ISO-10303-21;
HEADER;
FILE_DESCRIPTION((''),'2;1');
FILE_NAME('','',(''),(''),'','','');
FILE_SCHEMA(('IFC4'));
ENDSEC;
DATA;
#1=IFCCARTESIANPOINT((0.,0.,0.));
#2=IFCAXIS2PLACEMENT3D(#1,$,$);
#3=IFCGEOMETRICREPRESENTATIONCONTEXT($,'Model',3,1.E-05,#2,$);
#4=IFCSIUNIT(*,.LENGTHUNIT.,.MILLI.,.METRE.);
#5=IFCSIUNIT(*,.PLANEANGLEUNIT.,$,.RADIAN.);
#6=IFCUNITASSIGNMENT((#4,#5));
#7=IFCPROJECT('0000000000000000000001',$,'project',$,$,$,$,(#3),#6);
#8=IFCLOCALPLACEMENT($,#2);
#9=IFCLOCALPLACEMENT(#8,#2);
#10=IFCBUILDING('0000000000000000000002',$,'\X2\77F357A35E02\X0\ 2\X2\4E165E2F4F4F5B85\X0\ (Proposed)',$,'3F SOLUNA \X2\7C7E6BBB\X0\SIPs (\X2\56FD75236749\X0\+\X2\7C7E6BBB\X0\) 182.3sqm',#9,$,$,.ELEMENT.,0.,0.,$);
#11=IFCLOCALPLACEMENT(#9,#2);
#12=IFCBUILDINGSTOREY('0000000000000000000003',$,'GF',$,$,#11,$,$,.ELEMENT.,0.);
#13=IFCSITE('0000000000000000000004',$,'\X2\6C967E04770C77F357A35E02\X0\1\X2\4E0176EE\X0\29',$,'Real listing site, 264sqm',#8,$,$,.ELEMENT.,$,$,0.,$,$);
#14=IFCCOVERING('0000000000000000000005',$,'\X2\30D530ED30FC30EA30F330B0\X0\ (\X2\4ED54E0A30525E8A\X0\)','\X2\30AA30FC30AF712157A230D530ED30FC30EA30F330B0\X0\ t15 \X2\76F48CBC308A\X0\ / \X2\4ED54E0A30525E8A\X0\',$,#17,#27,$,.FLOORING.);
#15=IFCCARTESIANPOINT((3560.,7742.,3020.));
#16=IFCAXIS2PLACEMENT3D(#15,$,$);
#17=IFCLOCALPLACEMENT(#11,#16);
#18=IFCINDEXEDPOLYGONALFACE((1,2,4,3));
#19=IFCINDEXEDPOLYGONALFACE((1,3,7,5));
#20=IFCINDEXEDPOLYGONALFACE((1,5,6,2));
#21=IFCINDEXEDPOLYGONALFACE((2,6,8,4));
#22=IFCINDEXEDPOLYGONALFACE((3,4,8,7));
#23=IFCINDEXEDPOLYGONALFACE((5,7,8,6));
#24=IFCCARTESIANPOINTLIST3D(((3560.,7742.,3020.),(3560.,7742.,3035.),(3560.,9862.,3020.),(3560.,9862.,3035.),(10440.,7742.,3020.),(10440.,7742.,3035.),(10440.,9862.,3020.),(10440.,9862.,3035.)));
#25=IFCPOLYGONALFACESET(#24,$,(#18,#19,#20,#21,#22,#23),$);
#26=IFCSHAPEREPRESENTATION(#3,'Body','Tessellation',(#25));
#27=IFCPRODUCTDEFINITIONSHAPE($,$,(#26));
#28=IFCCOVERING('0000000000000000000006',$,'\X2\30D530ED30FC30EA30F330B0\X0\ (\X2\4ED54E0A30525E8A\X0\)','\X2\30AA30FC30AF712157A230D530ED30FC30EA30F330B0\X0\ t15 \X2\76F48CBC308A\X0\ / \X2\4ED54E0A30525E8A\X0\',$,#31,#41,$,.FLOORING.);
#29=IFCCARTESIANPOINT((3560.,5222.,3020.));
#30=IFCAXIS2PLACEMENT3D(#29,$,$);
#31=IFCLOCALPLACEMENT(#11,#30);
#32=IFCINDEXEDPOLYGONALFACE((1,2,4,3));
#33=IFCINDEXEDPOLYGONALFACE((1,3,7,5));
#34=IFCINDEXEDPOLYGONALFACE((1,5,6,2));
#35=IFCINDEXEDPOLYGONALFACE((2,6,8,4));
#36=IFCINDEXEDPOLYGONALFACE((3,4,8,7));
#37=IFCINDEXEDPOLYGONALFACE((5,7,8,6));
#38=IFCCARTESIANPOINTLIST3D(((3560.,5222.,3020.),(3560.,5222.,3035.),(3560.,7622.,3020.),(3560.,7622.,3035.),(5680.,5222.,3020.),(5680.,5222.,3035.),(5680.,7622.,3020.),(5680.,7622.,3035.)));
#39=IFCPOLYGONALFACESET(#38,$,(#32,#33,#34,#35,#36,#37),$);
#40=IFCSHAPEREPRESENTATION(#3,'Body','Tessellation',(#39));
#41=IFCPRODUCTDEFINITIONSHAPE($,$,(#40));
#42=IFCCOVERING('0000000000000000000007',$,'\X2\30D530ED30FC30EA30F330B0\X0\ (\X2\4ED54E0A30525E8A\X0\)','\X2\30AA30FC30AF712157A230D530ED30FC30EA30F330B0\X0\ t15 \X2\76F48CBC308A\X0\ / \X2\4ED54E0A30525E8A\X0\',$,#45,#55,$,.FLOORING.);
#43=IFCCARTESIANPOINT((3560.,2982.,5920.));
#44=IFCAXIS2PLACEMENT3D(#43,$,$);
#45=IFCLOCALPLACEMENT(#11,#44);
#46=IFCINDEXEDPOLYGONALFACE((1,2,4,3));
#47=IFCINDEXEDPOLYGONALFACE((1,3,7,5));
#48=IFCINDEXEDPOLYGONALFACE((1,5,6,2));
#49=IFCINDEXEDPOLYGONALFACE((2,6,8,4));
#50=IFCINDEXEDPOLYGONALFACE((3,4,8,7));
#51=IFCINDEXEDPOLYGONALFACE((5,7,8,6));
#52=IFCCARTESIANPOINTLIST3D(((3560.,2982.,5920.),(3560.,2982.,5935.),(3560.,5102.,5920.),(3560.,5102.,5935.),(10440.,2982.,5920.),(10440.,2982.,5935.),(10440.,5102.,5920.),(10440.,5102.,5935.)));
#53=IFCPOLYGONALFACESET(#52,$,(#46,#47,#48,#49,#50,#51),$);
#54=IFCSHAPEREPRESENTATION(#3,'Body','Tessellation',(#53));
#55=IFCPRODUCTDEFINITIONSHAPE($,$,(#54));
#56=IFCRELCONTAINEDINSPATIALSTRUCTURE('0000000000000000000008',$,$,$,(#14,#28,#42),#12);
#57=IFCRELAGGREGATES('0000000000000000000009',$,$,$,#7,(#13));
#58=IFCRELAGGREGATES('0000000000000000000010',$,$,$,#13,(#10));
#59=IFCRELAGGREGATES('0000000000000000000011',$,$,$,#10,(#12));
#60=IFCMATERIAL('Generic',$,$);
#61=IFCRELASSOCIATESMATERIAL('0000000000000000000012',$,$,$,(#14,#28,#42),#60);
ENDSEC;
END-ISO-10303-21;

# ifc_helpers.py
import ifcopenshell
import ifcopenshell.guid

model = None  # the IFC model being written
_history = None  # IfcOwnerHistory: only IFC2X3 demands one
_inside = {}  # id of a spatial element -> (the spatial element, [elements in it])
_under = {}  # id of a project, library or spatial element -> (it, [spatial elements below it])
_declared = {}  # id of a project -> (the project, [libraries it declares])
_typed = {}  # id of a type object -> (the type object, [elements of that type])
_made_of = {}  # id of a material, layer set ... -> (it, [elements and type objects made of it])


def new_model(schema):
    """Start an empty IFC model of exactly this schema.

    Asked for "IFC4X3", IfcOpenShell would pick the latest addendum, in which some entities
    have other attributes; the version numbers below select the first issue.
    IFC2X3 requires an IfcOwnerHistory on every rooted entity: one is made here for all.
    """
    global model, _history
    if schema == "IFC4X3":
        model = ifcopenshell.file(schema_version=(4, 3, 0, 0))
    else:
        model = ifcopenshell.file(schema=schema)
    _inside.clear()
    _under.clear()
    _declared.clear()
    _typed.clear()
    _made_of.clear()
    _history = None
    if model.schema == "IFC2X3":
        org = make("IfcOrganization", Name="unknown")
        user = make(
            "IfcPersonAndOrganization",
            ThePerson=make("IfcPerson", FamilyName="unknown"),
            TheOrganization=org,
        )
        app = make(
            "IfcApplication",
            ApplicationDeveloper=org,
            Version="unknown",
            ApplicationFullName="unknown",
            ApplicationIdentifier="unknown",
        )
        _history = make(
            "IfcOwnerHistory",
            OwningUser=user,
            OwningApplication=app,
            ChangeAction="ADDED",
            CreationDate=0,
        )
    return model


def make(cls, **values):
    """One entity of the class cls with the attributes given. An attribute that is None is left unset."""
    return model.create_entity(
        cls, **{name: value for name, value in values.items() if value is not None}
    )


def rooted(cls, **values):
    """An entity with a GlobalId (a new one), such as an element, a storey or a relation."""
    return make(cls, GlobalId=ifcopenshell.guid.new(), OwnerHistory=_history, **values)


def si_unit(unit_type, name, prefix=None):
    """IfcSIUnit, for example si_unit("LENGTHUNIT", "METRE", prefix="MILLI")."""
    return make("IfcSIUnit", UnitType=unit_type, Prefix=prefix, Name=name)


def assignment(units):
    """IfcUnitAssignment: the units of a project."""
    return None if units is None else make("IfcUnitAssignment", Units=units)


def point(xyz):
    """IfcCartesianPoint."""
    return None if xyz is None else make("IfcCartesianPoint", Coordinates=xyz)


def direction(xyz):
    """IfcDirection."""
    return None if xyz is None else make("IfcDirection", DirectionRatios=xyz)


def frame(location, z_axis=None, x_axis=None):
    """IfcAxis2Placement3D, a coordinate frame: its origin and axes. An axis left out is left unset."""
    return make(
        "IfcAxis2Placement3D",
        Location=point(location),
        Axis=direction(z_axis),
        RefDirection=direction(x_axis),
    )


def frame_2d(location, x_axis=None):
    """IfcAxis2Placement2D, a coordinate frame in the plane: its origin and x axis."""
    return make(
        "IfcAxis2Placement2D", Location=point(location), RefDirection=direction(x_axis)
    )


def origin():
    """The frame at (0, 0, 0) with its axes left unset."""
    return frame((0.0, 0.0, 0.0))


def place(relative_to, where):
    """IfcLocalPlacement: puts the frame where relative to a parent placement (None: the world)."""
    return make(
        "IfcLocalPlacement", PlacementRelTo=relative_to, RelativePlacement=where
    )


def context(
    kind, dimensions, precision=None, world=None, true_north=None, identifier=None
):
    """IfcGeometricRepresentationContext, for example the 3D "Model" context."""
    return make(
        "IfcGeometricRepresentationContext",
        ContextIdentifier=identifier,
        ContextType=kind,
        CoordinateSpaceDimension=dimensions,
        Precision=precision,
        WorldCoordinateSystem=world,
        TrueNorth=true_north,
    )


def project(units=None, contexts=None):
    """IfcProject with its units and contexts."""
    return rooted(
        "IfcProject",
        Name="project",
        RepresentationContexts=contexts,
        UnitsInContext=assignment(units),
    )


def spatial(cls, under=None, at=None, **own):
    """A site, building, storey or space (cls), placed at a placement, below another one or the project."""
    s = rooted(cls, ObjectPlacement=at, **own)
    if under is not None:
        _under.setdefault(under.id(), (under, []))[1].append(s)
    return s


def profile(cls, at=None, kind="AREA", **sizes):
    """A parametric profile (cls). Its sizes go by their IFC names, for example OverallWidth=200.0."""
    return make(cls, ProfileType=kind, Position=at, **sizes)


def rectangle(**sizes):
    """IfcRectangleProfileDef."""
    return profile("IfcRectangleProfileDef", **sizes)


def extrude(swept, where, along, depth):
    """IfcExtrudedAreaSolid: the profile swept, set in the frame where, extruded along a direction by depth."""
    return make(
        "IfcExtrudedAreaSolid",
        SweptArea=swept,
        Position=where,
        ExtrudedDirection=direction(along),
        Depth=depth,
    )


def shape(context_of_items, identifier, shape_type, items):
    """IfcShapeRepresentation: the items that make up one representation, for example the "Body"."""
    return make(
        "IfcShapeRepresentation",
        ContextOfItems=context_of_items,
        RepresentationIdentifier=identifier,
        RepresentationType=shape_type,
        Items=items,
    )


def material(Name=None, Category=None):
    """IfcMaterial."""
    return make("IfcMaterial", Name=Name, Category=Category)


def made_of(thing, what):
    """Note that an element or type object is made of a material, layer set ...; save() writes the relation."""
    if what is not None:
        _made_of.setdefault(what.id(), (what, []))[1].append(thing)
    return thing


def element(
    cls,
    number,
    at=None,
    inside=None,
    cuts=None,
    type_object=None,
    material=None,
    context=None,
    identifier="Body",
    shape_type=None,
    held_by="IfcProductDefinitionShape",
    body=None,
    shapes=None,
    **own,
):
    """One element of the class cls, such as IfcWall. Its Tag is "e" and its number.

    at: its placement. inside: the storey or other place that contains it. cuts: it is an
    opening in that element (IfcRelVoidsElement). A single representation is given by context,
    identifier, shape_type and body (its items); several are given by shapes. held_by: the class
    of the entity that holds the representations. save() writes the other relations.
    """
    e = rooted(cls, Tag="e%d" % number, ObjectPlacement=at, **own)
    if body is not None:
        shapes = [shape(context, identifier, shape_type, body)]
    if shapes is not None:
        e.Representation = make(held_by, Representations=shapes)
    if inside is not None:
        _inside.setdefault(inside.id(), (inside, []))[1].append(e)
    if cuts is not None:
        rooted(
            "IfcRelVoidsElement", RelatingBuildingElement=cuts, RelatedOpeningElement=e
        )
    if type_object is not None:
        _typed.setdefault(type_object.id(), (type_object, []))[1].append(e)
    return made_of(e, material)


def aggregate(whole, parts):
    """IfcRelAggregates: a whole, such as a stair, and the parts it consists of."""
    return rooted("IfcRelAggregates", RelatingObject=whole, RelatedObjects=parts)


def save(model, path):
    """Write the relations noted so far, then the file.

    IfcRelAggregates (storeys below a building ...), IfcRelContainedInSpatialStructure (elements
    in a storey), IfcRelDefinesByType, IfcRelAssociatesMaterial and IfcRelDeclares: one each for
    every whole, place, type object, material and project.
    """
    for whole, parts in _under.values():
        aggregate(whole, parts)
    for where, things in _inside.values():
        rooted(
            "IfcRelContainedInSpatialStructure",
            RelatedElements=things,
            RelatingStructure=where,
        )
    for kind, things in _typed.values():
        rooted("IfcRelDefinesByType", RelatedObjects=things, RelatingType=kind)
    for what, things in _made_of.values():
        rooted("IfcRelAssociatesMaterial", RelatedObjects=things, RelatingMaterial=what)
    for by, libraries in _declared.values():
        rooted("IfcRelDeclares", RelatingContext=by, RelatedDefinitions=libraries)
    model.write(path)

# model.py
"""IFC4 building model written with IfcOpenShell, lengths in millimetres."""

from ifc_helpers import new_model, si_unit, frame, frame_2d, origin, place, context, project, spatial, rectangle, extrude, material, element, save


model = new_model("IFC4")

# Units and contexts
model_context = context("Model", 3, precision=1e-05, world=origin())
ifc_project = project(units=[si_unit("LENGTHUNIT", "METRE", prefix="MILLI"), si_unit("PLANEANGLEUNIT", "RADIAN")], contexts=[model_context])

# Site, building, storey
site_placement = place(None, origin())
site = spatial("IfcSite", under=ifc_project, at=site_placement, Name="沖縄県石垣市1丁目29", ObjectType="Real listing site, 264sqm", CompositionType="ELEMENT", RefElevation=0.0)
building_placement = place(site_placement, origin())
building = spatial("IfcBuilding", under=site, at=building_placement, Name="石垣市 2世帯住宅 (Proposed)", ObjectType="3F SOLUNA 籾殻SIPs (国産杉+籾殻) 182.3sqm", CompositionType="ELEMENT", ElevationOfRefHeight=0.0, ElevationOfTerrain=0.0)
storey_placement = place(building_placement, origin())
storey = spatial("IfcBuildingStorey", under=building, at=storey_placement, Name="GF", CompositionType="ELEMENT", Elevation=0.0)

# Shared definitions
ifc_material_1 = material(Name="Generic")

# Coverings
covering_1_placement = place(storey_placement, frame((3560.0, 7742.0, 3020.0)))
element("IfcCovering", 1, at=covering_1_placement, inside=storey, material=ifc_material_1, Name="フローリング (仕上げ床)", Description="オーク無垢フローリング t15 直貼り / 仕上げ床", PredefinedType="FLOORING", context=model_context, shape_type="SweptSolid", body=[
    extrude(rectangle(XDim=6880.0, YDim=2120.0, at=frame_2d((3440.0, 1060.0))), frame((3560.0, 7742.0, 3020.0)), (0.0, 0.0, 1.0), 15.0),
])
covering_2_placement = place(storey_placement, frame((3560.0, 5222.0, 3020.0)))
element("IfcCovering", 2, at=covering_2_placement, inside=storey, material=ifc_material_1, Name="フローリング (仕上げ床)", Description="オーク無垢フローリング t15 直貼り / 仕上げ床", PredefinedType="FLOORING", context=model_context, shape_type="SweptSolid", body=[
    extrude(rectangle(XDim=2120.0, YDim=2400.0, at=frame_2d((1060.0, 1200.0))), frame((3560.0, 5222.0, 3020.0)), (0.0, 0.0, 1.0), 15.0),
])
covering_3_placement = place(storey_placement, frame((3560.0, 2982.0, 5920.0)))
element("IfcCovering", 3, at=covering_3_placement, inside=storey, material=ifc_material_1, Name="フローリング (仕上げ床)", Description="オーク無垢フローリング t15 直貼り / 仕上げ床", PredefinedType="FLOORING", context=model_context, shape_type="SweptSolid", body=[
    extrude(rectangle(XDim=6880.0, YDim=2120.0, at=frame_2d((3440.0, 1060.0))), frame((3560.0, 2982.0, 5920.0)), (0.0, 0.0, 1.0), 15.0),
])

save(model, "model.ifc")
